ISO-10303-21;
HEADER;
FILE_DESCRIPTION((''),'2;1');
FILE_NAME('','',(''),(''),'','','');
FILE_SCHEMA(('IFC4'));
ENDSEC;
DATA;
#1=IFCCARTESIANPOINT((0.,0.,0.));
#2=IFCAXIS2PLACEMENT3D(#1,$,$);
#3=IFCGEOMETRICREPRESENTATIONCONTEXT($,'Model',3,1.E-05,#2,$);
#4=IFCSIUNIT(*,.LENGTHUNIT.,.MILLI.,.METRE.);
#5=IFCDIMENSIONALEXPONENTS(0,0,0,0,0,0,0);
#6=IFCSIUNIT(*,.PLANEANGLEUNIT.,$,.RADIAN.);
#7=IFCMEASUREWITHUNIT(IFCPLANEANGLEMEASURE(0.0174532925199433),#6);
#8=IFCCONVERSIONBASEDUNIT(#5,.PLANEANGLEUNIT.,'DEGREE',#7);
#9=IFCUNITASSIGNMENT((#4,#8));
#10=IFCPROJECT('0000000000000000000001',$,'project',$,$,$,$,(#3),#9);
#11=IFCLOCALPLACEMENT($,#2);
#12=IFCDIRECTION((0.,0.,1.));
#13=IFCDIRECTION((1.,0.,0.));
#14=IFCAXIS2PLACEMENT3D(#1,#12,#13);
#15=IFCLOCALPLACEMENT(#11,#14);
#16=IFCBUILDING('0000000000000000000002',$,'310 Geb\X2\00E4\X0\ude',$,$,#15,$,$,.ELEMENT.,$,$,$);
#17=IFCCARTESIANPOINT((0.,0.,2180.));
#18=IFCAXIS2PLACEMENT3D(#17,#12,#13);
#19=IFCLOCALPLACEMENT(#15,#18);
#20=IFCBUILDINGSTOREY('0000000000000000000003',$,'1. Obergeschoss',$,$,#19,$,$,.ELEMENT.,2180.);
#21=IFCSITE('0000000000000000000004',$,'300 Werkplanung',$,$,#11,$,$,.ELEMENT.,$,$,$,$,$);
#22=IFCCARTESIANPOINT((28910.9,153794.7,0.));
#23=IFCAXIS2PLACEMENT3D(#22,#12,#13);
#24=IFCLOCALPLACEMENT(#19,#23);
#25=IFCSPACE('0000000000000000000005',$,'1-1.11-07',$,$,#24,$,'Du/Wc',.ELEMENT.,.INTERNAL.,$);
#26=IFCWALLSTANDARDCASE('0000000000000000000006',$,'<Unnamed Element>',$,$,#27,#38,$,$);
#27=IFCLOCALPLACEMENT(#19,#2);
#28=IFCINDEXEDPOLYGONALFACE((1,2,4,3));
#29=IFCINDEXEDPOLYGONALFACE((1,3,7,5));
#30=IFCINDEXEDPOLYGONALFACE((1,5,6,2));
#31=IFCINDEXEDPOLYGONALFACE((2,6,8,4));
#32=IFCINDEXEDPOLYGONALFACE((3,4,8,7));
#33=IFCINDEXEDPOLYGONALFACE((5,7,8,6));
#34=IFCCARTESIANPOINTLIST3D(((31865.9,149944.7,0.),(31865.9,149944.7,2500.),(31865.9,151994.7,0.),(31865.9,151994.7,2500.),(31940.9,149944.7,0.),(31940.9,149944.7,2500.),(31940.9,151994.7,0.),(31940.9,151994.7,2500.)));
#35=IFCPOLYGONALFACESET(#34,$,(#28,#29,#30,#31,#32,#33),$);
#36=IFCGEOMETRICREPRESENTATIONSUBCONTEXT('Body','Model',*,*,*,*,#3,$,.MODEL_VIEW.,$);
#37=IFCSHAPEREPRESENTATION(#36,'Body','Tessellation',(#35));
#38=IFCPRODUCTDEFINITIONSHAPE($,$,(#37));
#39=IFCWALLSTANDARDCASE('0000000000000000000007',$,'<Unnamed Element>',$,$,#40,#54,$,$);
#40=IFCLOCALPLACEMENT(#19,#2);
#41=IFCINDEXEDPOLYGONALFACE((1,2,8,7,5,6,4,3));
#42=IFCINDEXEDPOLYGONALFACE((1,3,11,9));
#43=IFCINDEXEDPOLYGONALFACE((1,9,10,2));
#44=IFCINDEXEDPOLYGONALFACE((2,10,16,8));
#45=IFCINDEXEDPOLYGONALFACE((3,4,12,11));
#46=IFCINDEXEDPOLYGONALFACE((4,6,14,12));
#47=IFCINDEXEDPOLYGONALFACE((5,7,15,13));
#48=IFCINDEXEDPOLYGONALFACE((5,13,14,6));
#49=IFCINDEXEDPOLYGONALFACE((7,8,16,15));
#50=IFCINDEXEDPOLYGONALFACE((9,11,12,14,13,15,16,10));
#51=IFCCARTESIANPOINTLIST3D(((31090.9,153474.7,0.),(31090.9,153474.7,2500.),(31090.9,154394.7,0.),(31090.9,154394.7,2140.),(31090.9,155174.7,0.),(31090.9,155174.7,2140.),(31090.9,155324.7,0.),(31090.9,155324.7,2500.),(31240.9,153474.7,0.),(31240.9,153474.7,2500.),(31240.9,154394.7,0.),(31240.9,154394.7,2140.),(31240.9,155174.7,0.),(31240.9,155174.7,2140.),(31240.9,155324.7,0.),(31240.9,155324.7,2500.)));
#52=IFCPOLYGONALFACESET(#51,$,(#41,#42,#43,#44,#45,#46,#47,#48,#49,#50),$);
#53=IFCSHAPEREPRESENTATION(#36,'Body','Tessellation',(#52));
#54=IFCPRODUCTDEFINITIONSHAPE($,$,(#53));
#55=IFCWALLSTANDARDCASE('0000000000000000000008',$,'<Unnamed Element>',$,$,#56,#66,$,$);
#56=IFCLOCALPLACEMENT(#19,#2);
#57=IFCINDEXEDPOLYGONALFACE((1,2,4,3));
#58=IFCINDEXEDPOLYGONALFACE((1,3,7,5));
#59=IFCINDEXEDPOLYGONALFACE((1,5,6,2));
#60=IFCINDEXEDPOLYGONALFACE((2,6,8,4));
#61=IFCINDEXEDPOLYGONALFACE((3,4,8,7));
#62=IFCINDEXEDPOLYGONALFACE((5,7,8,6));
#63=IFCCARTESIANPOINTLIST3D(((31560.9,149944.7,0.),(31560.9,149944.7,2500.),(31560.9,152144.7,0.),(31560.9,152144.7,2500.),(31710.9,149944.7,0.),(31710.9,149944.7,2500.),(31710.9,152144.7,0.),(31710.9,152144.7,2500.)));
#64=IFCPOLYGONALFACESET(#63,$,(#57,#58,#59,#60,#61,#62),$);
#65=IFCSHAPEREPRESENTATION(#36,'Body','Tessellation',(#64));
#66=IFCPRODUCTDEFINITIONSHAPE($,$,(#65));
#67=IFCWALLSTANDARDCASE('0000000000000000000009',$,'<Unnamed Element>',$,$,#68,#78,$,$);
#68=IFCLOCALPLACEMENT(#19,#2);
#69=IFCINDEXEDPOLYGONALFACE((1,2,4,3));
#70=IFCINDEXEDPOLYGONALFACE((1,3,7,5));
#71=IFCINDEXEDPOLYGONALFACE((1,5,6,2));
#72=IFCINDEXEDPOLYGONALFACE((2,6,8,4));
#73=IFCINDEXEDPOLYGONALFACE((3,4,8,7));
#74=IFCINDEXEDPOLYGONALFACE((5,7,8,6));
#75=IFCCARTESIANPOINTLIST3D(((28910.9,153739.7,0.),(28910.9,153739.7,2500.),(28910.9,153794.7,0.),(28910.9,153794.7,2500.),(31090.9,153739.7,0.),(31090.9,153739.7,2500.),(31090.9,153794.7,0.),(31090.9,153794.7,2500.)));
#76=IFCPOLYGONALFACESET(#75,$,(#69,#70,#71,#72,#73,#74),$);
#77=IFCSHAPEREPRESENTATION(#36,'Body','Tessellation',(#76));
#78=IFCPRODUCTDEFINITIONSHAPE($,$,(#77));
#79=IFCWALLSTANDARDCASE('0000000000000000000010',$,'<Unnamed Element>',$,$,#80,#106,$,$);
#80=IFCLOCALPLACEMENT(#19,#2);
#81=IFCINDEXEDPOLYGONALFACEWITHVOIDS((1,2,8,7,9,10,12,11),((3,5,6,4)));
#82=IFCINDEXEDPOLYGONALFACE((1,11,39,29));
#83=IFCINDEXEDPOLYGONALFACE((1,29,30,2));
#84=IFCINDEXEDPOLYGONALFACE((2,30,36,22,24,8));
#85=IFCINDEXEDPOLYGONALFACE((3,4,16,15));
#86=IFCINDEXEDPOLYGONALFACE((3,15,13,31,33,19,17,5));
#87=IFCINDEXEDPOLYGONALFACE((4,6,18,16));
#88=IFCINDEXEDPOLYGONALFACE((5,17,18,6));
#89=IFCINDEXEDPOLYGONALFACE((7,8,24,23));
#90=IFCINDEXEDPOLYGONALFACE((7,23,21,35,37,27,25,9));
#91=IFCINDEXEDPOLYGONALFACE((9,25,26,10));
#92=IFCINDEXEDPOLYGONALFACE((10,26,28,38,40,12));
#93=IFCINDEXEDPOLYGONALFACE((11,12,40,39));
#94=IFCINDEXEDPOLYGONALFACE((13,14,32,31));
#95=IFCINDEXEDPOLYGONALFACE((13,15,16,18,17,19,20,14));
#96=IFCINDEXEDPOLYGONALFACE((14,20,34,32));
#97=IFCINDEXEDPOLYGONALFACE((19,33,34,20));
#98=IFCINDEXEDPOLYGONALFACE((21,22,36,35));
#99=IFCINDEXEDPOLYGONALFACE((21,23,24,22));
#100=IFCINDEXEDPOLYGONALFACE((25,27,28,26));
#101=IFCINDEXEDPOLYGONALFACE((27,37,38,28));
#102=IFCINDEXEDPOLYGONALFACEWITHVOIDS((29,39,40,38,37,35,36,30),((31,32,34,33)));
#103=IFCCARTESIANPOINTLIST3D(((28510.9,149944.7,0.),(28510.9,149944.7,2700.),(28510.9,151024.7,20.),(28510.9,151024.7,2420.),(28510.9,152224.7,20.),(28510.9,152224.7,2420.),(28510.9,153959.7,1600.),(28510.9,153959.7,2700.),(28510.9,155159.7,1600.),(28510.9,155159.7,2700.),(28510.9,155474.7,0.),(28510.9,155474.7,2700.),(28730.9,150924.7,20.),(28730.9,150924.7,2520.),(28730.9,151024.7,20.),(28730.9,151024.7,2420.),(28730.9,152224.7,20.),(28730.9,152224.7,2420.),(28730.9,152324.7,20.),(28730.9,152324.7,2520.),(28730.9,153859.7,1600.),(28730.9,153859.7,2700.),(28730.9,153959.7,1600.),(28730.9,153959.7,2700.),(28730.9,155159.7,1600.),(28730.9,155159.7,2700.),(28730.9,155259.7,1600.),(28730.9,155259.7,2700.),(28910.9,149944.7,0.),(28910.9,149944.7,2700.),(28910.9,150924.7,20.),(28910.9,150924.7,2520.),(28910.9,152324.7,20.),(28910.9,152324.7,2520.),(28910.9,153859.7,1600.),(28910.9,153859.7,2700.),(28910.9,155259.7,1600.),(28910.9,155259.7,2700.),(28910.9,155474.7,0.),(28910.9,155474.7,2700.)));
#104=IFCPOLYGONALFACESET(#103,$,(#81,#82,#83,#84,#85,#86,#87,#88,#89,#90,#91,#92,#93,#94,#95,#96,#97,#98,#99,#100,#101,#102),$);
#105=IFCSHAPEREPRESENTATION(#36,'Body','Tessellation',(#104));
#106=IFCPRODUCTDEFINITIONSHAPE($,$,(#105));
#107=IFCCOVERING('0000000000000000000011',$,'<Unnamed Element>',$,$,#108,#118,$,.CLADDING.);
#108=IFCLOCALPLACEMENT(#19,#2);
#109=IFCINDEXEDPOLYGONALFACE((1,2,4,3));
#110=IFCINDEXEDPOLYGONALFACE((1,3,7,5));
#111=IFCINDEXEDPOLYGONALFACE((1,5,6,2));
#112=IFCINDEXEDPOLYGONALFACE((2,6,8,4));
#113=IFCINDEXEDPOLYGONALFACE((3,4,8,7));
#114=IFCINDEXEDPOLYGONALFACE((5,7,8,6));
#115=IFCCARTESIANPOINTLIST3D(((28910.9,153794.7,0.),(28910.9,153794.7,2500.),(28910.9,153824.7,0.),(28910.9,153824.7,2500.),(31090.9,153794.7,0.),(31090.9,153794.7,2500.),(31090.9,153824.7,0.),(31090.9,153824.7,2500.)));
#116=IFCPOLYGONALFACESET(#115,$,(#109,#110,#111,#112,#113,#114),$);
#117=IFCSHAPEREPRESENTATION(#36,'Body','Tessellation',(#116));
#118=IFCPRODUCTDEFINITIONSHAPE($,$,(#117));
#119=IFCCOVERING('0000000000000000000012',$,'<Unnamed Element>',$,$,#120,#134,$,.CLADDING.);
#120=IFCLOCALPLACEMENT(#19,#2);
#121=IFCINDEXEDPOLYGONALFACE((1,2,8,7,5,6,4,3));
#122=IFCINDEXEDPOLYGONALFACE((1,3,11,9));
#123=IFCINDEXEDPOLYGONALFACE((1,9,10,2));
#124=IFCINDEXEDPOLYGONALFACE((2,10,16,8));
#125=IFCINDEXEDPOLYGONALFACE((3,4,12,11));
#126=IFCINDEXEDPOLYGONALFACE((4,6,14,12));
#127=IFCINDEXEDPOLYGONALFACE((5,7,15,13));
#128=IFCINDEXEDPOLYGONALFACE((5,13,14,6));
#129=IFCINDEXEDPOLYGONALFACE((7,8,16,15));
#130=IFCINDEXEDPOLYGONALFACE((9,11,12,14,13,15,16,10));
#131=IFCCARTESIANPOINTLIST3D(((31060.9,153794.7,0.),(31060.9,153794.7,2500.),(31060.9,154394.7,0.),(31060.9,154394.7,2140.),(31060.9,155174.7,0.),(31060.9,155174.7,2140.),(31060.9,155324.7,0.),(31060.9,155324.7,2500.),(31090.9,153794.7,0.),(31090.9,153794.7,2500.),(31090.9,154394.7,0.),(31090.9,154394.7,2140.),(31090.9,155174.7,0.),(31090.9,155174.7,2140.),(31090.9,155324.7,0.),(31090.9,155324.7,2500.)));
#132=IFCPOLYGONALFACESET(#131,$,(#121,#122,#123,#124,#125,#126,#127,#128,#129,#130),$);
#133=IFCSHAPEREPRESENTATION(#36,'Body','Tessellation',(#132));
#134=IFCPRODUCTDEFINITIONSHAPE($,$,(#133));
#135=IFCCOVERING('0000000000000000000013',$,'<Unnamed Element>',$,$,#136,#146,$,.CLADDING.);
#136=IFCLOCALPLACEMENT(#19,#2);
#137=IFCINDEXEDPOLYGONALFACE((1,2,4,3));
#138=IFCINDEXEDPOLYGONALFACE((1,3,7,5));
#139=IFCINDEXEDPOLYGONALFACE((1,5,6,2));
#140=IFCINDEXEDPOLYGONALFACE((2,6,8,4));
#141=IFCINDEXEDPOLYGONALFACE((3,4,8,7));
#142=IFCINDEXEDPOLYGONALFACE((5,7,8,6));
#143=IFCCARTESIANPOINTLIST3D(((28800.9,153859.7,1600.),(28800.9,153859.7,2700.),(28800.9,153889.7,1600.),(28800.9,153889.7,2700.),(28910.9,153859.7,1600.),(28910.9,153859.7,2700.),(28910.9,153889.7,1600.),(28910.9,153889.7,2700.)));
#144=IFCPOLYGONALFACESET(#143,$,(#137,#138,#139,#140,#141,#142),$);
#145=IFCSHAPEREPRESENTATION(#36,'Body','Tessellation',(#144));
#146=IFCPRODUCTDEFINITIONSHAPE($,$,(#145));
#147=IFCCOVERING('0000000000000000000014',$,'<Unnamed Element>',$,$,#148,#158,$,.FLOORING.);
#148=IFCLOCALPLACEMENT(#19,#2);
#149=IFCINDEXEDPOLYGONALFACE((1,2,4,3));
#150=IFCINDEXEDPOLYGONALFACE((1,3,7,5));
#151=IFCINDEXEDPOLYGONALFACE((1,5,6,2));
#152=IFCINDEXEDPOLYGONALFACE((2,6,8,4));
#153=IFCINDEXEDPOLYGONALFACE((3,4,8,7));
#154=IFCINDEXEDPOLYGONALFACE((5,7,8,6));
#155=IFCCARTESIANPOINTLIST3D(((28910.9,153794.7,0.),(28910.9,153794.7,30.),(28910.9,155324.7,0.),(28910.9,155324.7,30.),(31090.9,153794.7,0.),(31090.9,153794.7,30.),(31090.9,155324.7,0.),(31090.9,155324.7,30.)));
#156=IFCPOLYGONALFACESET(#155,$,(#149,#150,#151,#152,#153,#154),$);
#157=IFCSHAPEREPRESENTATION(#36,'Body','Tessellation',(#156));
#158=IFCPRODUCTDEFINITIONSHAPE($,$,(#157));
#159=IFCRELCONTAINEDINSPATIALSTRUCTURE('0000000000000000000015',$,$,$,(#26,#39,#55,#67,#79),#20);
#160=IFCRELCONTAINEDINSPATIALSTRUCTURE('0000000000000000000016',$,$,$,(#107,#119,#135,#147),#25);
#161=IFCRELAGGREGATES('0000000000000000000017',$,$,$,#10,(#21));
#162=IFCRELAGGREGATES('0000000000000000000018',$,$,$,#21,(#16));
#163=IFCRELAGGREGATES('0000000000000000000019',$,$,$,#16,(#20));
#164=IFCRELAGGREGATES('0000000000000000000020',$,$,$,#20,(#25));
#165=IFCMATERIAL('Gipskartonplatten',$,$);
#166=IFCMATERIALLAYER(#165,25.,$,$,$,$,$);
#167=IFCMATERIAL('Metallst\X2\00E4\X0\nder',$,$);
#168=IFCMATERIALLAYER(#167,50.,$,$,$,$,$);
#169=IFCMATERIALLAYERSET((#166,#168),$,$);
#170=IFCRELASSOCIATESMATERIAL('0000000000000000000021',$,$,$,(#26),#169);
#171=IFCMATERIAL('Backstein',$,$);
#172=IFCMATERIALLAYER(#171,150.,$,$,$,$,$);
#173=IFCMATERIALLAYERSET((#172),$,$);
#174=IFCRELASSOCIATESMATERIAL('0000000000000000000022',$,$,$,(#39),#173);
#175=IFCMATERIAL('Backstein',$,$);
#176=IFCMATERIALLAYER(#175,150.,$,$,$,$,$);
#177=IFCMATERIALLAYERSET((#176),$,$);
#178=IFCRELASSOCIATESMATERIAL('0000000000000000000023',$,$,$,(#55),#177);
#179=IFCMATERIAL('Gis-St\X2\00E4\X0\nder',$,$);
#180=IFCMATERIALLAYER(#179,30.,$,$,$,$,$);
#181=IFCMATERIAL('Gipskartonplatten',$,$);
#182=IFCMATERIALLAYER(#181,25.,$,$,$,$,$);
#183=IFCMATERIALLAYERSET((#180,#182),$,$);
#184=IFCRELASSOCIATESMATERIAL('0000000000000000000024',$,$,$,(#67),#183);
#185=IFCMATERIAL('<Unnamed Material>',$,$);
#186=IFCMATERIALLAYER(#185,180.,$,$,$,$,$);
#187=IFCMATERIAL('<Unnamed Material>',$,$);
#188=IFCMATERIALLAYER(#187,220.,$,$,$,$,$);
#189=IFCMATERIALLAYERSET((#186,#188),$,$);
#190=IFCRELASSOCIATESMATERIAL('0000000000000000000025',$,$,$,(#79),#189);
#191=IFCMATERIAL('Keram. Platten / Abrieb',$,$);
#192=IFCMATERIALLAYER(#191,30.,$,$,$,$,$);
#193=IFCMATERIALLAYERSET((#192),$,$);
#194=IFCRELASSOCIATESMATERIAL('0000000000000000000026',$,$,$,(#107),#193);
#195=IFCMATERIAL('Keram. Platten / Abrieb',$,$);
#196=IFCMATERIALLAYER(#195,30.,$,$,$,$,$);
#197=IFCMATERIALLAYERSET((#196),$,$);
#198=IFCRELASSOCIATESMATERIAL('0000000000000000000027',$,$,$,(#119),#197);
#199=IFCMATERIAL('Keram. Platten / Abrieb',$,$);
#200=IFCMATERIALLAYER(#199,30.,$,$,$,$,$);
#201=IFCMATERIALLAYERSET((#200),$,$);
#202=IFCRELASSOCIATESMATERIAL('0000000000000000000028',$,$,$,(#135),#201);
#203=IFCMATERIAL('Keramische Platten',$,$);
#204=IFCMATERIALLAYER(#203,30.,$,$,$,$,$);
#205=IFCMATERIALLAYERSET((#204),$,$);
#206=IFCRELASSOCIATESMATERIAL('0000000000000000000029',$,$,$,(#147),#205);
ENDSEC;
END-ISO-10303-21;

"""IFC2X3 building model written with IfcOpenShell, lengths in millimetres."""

from ifc_helpers import new_model, entity, si_unit, converted_unit, frame, frame_2d, origin, origin_with_axes, place, context, subcontext, project, spatial, polyline, rectangle, outline, extrude, material, layer, layer_set, layer_usage, element, save


model = new_model("IFC2X3")

# Units and contexts
model_context = context("Model", 3, precision=1e-05, world=origin())
body_context = subcontext(model_context, "Body", "Model", "MODEL_VIEW")
ifc_project = project(units=[si_unit("LENGTHUNIT", "METRE", prefix="MILLI"), converted_unit("PLANEANGLEUNIT", "DEGREE", entity("IfcPlaneAngleMeasure", 0.0174532925199433), si_unit("PLANEANGLEUNIT", "RADIAN"), dimensions=[0, 0, 0, 0, 0, 0, 0])], contexts=[model_context])

# Site, building, storey
site_placement = place(None, origin())
site = spatial("IfcSite", under=ifc_project, at=site_placement, Name="300 Werkplanung", CompositionType="ELEMENT")
building_placement = place(site_placement, origin_with_axes())
building = spatial("IfcBuilding", under=site, at=building_placement, Name="310 Gebäude", CompositionType="ELEMENT")
storey_placement = place(building_placement, frame((0.0, 0.0, 2180.0), z_axis=(0.0, 0.0, 1.0), x_axis=(1.0, 0.0, 0.0)))
storey = spatial("IfcBuildingStorey", under=building, at=storey_placement, Name="1. Obergeschoss", CompositionType="ELEMENT", Elevation=2180.0)

# Wall
ifc_material_1 = material(Name="Gipskartonplatten")
ifc_layer_1 = layer(ifc_material_1, 25.0)
ifc_material_2 = material(Name="Metallständer")
ifc_layer_2 = layer(ifc_material_2, 50.0)
ifc_layer_set_1 = layer_set([ifc_layer_1, ifc_layer_2])
ifc_layer_usage_1 = layer_usage(ifc_layer_set_1, "AXIS2", "POSITIVE", 0.0)
wall_1_placement = place(storey_placement, frame((31940.9, 149944.7, 0.0), z_axis=(0.0, 0.0, 1.0), x_axis=(0.0, 1.0, 0.0)))
element("IfcWallStandardCase", 1, at=wall_1_placement, inside=storey, material=ifc_layer_usage_1, Name="<Unnamed Element>", context=body_context, shape_type="SweptSolid", body=[
    extrude(rectangle(XDim=2050.0, YDim=75.0, at=frame_2d((1025.0, 37.5), x_axis=(1.0, 0.0))), origin_with_axes(), (0.0, 0.0, 1.0), 2500.0),
])

# Wall, opening
ifc_material_3 = material(Name="Backstein")
ifc_layer_3 = layer(ifc_material_3, 150.0)
ifc_layer_set_2 = layer_set([ifc_layer_3])
ifc_layer_usage_2 = layer_usage(ifc_layer_set_2, "AXIS2", "POSITIVE", 0.0)
wall_2_placement = place(storey_placement, frame((31240.9, 153474.7, 0.0), z_axis=(0.0, 0.0, 1.0), x_axis=(0.0, 1.0, 0.0)))
wall_2 = element("IfcWallStandardCase", 2, at=wall_2_placement, inside=storey, material=ifc_layer_usage_2, Name="<Unnamed Element>", context=body_context, shape_type="SweptSolid", body=[
    extrude(rectangle(XDim=1850.0, YDim=150.0, at=frame_2d((925.0, 75.0), x_axis=(1.0, 0.0))), origin_with_axes(), (0.0, 0.0, 1.0), 2500.0),
])
opening_1_placement = place(wall_2_placement, frame((920.0, 0.0, 0.0), z_axis=(0.0, 1.0, 0.0), x_axis=(0.0, 0.0, 1.0)))
element("IfcOpeningElement", 3, at=opening_1_placement, cuts=wall_2, ObjectType="Opening", context=body_context, shape_type="SweptSolid", body=[
    extrude(rectangle(XDim=2140.0, YDim=780.0, at=frame_2d((1070.0, 390.0), x_axis=(1.0, 0.0))), origin_with_axes(), (0.0, 0.0, 1.0), 150.0),
])

# Walls
ifc_material_4 = material(Name="Backstein")
ifc_layer_4 = layer(ifc_material_4, 150.0)
ifc_layer_set_3 = layer_set([ifc_layer_4])
ifc_layer_usage_3 = layer_usage(ifc_layer_set_3, "AXIS2", "POSITIVE", 0.0)
wall_3_placement = place(storey_placement, frame((31710.9, 149944.7, 0.0), z_axis=(0.0, 0.0, 1.0), x_axis=(0.0, 1.0, 0.0)))
element("IfcWallStandardCase", 4, at=wall_3_placement, inside=storey, material=ifc_layer_usage_3, Name="<Unnamed Element>", context=body_context, shape_type="SweptSolid", body=[
    extrude(rectangle(XDim=2200.0, YDim=150.0, at=frame_2d((1100.0, 75.0), x_axis=(1.0, 0.0))), origin_with_axes(), (0.0, 0.0, 1.0), 2500.0),
])
ifc_material_5 = material(Name="Gis-Ständer")
ifc_layer_5 = layer(ifc_material_5, 30.0)
ifc_material_6 = material(Name="Gipskartonplatten")
ifc_layer_6 = layer(ifc_material_6, 25.0)
ifc_layer_set_4 = layer_set([ifc_layer_5, ifc_layer_6])
ifc_layer_usage_4 = layer_usage(ifc_layer_set_4, "AXIS2", "POSITIVE", -55.0)
wall_4_placement = place(storey_placement, frame((28910.9, 153739.7, 0.0), z_axis=(0.0, 0.0, 1.0), x_axis=(1.0, 0.0, 0.0)))
element("IfcWallStandardCase", 5, at=wall_4_placement, inside=storey, material=ifc_layer_usage_4, Name="<Unnamed Element>", context=body_context, shape_type="SweptSolid", body=[
    extrude(rectangle(XDim=2180.0, YDim=55.0, at=frame_2d((1090.0, 27.5), x_axis=(1.0, 0.0))), origin_with_axes(), (0.0, 0.0, 1.0), 2500.0),
])

# Wall, openings
ifc_material_7 = material(Name="<Unnamed Material>")
ifc_layer_7 = layer(ifc_material_7, 180.0)
ifc_material_8 = material(Name="<Unnamed Material>")
ifc_layer_8 = layer(ifc_material_8, 220.0)
ifc_layer_set_5 = layer_set([ifc_layer_7, ifc_layer_8])
ifc_layer_usage_5 = layer_usage(ifc_layer_set_5, "AXIS2", "POSITIVE", -175.0)
wall_5_placement = place(storey_placement, frame((28910.9, 149944.7, 0.0), z_axis=(0.0, 0.0, 1.0), x_axis=(0.0, 1.0, 0.0)))
wall_5 = element("IfcWallStandardCase", 6, at=wall_5_placement, inside=storey, material=ifc_layer_usage_5, Name="<Unnamed Element>", context=body_context, shape_type="SweptSolid", body=[
    extrude(rectangle(XDim=5530.0, YDim=400.0, at=frame_2d((2765.0, 200.0), x_axis=(1.0, 0.0))), origin_with_axes(), (0.0, 0.0, 1.0), 2700.0),
])
opening_2_placement = place(wall_5_placement, frame((980.0, 0.0, 20.0), z_axis=(0.0, 1.0, 0.0), x_axis=(0.0, 0.0, 1.0)))
element("IfcOpeningElement", 7, at=opening_2_placement, cuts=wall_5, ObjectType="Opening", context=body_context, shape_type="SweptSolid", body=[
    extrude(rectangle(XDim=2500.0, YDim=1400.0, at=frame_2d((1250.0, 700.0), x_axis=(1.0, 0.0))), origin_with_axes(), (0.0, 0.0, 1.0), 180.0),
    extrude(rectangle(XDim=2400.0, YDim=1200.0, at=frame_2d((1200.0, 600.0), x_axis=(1.0, 0.0))), frame((0.0, 100.0, 180.0), z_axis=(0.0, 0.0, 1.0), x_axis=(1.0, 0.0, 0.0)), (0.0, 0.0, 1.0), 220.0),
])
opening_3_placement = place(wall_5_placement, frame((3915.0, 0.0, 1600.0), z_axis=(0.0, 1.0, 0.0), x_axis=(0.0, 0.0, 1.0)))
element("IfcOpeningElement", 8, at=opening_3_placement, cuts=wall_5, ObjectType="Opening", context=body_context, shape_type="SweptSolid", body=[
    extrude(rectangle(XDim=2500.0, YDim=1400.0, at=frame_2d((1250.0, 700.0), x_axis=(1.0, 0.0))), origin_with_axes(), (0.0, 0.0, 1.0), 180.0),
    extrude(rectangle(XDim=2400.0, YDim=1200.0, at=frame_2d((1200.0, 600.0), x_axis=(1.0, 0.0))), frame((0.0, 100.0, 180.0), z_axis=(0.0, 0.0, 1.0), x_axis=(1.0, 0.0, 0.0)), (0.0, 0.0, 1.0), 220.0),
])

# Shared definitions
space_1_placement = place(storey_placement, frame((28910.9, 153794.7, 0.0), z_axis=(0.0, 0.0, 1.0), x_axis=(1.0, 0.0, 0.0)))
space_1 = spatial("IfcSpace", under=storey, at=space_1_placement, Name="1-1.11-07", LongName="Du/Wc", CompositionType="ELEMENT", InteriorOrExteriorSpace="INTERNAL")

# Coverings
ifc_material_9 = material(Name="Keram. Platten / Abrieb")
ifc_layer_9 = layer(ifc_material_9, 30.0)
ifc_layer_set_6 = layer_set([ifc_layer_9])
ifc_layer_usage_6 = layer_usage(ifc_layer_set_6, "AXIS3", "POSITIVE", 0.0)
covering_1_placement = place(space_1_placement, frame((0.0, 0.0, 0.0), z_axis=(0.0, 0.0, 1.0), x_axis=(1.0, 0.0, 0.0)))
element("IfcCovering", 9, at=covering_1_placement, inside=space_1, material=ifc_layer_usage_6, Name="<Unnamed Element>", PredefinedType="CLADDING", context=body_context, shape_type="SweptSolid", body=[
    extrude(rectangle(XDim=2500.0, YDim=2180.0, at=frame_2d((-1090.0, 1250.0), x_axis=(0.0, 1.0))), frame((2180.0, 0.0, 2500.0), z_axis=(0.0, 1.0, 0.0), x_axis=(1.0, 0.0, 0.0)), (0.0, 0.0, 1.0), 30.0),
])
ifc_material_10 = material(Name="Keram. Platten / Abrieb")
ifc_layer_10 = layer(ifc_material_10, 30.0)
ifc_layer_set_7 = layer_set([ifc_layer_10])
ifc_layer_usage_7 = layer_usage(ifc_layer_set_7, "AXIS3", "POSITIVE", 0.0)
covering_2_placement = place(space_1_placement, frame((2180.0, 0.0, 0.0), z_axis=(0.0, 0.0, 1.0), x_axis=(0.0, 1.0, 0.0)))
element("IfcCovering", 10, at=covering_2_placement, inside=space_1, material=ifc_layer_usage_7, Name="<Unnamed Element>", PredefinedType="CLADDING", context=body_context, shape_type="SweptSolid", body=[
    extrude(outline(polyline([(1530.0, 0.0), (1530.0, -2500.0), (0.0, -2500.0), (0.0, 0.0), (600.0, 0.0), (600.0, -2140.0), (1380.0, -2140.0), (1380.0, 0.0), (1530.0, 0.0)])), frame((0.0, 0.0, 0.0), z_axis=(0.0, 1.0, 0.0), x_axis=(1.0, 0.0, 0.0)), (0.0, 0.0, 1.0), 30.0),
])
ifc_material_11 = material(Name="Keram. Platten / Abrieb")
ifc_layer_11 = layer(ifc_material_11, 30.0)
ifc_layer_set_8 = layer_set([ifc_layer_11])
ifc_layer_usage_8 = layer_usage(ifc_layer_set_8, "AXIS3", "POSITIVE", 0.0)
covering_3_placement = place(space_1_placement, frame((-110.0, 65.0, 1600.0), z_axis=(0.0, 0.0, 1.0), x_axis=(1.0, 0.0, 0.0)))
element("IfcCovering", 11, at=covering_3_placement, inside=space_1, material=ifc_layer_usage_8, Name="<Unnamed Element>", PredefinedType="CLADDING", context=body_context, shape_type="SweptSolid", body=[
    extrude(rectangle(XDim=1100.0, YDim=110.0, at=frame_2d((-55.0, 550.0), x_axis=(0.0, 1.0))), frame((110.0, 0.0, 1100.0), z_axis=(0.0, 1.0, 0.0), x_axis=(1.0, 0.0, 0.0)), (0.0, 0.0, 1.0), 30.0),
])
ifc_material_12 = material(Name="Keramische Platten")
ifc_layer_12 = layer(ifc_material_12, 30.0)
ifc_layer_set_9 = layer_set([ifc_layer_12])
ifc_layer_usage_9 = layer_usage(ifc_layer_set_9, "AXIS3", "POSITIVE", 0.0)
covering_4_placement = place(space_1_placement, origin_with_axes())
element("IfcCovering", 12, at=covering_4_placement, inside=space_1, material=ifc_layer_usage_9, Name="<Unnamed Element>", PredefinedType="FLOORING", context=body_context, shape_type="SweptSolid", body=[
    extrude(rectangle(XDim=2180.0, YDim=1530.0, at=frame_2d((-1090.0, -765.0), x_axis=(-1.0, 0.0))), frame((2180.0, 1530.0, 0.0), z_axis=(0.0, 0.0, 1.0), x_axis=(1.0, 0.0, 0.0)), (0.0, 0.0, 1.0), 30.0),
])

save(model, "model.ifc")
